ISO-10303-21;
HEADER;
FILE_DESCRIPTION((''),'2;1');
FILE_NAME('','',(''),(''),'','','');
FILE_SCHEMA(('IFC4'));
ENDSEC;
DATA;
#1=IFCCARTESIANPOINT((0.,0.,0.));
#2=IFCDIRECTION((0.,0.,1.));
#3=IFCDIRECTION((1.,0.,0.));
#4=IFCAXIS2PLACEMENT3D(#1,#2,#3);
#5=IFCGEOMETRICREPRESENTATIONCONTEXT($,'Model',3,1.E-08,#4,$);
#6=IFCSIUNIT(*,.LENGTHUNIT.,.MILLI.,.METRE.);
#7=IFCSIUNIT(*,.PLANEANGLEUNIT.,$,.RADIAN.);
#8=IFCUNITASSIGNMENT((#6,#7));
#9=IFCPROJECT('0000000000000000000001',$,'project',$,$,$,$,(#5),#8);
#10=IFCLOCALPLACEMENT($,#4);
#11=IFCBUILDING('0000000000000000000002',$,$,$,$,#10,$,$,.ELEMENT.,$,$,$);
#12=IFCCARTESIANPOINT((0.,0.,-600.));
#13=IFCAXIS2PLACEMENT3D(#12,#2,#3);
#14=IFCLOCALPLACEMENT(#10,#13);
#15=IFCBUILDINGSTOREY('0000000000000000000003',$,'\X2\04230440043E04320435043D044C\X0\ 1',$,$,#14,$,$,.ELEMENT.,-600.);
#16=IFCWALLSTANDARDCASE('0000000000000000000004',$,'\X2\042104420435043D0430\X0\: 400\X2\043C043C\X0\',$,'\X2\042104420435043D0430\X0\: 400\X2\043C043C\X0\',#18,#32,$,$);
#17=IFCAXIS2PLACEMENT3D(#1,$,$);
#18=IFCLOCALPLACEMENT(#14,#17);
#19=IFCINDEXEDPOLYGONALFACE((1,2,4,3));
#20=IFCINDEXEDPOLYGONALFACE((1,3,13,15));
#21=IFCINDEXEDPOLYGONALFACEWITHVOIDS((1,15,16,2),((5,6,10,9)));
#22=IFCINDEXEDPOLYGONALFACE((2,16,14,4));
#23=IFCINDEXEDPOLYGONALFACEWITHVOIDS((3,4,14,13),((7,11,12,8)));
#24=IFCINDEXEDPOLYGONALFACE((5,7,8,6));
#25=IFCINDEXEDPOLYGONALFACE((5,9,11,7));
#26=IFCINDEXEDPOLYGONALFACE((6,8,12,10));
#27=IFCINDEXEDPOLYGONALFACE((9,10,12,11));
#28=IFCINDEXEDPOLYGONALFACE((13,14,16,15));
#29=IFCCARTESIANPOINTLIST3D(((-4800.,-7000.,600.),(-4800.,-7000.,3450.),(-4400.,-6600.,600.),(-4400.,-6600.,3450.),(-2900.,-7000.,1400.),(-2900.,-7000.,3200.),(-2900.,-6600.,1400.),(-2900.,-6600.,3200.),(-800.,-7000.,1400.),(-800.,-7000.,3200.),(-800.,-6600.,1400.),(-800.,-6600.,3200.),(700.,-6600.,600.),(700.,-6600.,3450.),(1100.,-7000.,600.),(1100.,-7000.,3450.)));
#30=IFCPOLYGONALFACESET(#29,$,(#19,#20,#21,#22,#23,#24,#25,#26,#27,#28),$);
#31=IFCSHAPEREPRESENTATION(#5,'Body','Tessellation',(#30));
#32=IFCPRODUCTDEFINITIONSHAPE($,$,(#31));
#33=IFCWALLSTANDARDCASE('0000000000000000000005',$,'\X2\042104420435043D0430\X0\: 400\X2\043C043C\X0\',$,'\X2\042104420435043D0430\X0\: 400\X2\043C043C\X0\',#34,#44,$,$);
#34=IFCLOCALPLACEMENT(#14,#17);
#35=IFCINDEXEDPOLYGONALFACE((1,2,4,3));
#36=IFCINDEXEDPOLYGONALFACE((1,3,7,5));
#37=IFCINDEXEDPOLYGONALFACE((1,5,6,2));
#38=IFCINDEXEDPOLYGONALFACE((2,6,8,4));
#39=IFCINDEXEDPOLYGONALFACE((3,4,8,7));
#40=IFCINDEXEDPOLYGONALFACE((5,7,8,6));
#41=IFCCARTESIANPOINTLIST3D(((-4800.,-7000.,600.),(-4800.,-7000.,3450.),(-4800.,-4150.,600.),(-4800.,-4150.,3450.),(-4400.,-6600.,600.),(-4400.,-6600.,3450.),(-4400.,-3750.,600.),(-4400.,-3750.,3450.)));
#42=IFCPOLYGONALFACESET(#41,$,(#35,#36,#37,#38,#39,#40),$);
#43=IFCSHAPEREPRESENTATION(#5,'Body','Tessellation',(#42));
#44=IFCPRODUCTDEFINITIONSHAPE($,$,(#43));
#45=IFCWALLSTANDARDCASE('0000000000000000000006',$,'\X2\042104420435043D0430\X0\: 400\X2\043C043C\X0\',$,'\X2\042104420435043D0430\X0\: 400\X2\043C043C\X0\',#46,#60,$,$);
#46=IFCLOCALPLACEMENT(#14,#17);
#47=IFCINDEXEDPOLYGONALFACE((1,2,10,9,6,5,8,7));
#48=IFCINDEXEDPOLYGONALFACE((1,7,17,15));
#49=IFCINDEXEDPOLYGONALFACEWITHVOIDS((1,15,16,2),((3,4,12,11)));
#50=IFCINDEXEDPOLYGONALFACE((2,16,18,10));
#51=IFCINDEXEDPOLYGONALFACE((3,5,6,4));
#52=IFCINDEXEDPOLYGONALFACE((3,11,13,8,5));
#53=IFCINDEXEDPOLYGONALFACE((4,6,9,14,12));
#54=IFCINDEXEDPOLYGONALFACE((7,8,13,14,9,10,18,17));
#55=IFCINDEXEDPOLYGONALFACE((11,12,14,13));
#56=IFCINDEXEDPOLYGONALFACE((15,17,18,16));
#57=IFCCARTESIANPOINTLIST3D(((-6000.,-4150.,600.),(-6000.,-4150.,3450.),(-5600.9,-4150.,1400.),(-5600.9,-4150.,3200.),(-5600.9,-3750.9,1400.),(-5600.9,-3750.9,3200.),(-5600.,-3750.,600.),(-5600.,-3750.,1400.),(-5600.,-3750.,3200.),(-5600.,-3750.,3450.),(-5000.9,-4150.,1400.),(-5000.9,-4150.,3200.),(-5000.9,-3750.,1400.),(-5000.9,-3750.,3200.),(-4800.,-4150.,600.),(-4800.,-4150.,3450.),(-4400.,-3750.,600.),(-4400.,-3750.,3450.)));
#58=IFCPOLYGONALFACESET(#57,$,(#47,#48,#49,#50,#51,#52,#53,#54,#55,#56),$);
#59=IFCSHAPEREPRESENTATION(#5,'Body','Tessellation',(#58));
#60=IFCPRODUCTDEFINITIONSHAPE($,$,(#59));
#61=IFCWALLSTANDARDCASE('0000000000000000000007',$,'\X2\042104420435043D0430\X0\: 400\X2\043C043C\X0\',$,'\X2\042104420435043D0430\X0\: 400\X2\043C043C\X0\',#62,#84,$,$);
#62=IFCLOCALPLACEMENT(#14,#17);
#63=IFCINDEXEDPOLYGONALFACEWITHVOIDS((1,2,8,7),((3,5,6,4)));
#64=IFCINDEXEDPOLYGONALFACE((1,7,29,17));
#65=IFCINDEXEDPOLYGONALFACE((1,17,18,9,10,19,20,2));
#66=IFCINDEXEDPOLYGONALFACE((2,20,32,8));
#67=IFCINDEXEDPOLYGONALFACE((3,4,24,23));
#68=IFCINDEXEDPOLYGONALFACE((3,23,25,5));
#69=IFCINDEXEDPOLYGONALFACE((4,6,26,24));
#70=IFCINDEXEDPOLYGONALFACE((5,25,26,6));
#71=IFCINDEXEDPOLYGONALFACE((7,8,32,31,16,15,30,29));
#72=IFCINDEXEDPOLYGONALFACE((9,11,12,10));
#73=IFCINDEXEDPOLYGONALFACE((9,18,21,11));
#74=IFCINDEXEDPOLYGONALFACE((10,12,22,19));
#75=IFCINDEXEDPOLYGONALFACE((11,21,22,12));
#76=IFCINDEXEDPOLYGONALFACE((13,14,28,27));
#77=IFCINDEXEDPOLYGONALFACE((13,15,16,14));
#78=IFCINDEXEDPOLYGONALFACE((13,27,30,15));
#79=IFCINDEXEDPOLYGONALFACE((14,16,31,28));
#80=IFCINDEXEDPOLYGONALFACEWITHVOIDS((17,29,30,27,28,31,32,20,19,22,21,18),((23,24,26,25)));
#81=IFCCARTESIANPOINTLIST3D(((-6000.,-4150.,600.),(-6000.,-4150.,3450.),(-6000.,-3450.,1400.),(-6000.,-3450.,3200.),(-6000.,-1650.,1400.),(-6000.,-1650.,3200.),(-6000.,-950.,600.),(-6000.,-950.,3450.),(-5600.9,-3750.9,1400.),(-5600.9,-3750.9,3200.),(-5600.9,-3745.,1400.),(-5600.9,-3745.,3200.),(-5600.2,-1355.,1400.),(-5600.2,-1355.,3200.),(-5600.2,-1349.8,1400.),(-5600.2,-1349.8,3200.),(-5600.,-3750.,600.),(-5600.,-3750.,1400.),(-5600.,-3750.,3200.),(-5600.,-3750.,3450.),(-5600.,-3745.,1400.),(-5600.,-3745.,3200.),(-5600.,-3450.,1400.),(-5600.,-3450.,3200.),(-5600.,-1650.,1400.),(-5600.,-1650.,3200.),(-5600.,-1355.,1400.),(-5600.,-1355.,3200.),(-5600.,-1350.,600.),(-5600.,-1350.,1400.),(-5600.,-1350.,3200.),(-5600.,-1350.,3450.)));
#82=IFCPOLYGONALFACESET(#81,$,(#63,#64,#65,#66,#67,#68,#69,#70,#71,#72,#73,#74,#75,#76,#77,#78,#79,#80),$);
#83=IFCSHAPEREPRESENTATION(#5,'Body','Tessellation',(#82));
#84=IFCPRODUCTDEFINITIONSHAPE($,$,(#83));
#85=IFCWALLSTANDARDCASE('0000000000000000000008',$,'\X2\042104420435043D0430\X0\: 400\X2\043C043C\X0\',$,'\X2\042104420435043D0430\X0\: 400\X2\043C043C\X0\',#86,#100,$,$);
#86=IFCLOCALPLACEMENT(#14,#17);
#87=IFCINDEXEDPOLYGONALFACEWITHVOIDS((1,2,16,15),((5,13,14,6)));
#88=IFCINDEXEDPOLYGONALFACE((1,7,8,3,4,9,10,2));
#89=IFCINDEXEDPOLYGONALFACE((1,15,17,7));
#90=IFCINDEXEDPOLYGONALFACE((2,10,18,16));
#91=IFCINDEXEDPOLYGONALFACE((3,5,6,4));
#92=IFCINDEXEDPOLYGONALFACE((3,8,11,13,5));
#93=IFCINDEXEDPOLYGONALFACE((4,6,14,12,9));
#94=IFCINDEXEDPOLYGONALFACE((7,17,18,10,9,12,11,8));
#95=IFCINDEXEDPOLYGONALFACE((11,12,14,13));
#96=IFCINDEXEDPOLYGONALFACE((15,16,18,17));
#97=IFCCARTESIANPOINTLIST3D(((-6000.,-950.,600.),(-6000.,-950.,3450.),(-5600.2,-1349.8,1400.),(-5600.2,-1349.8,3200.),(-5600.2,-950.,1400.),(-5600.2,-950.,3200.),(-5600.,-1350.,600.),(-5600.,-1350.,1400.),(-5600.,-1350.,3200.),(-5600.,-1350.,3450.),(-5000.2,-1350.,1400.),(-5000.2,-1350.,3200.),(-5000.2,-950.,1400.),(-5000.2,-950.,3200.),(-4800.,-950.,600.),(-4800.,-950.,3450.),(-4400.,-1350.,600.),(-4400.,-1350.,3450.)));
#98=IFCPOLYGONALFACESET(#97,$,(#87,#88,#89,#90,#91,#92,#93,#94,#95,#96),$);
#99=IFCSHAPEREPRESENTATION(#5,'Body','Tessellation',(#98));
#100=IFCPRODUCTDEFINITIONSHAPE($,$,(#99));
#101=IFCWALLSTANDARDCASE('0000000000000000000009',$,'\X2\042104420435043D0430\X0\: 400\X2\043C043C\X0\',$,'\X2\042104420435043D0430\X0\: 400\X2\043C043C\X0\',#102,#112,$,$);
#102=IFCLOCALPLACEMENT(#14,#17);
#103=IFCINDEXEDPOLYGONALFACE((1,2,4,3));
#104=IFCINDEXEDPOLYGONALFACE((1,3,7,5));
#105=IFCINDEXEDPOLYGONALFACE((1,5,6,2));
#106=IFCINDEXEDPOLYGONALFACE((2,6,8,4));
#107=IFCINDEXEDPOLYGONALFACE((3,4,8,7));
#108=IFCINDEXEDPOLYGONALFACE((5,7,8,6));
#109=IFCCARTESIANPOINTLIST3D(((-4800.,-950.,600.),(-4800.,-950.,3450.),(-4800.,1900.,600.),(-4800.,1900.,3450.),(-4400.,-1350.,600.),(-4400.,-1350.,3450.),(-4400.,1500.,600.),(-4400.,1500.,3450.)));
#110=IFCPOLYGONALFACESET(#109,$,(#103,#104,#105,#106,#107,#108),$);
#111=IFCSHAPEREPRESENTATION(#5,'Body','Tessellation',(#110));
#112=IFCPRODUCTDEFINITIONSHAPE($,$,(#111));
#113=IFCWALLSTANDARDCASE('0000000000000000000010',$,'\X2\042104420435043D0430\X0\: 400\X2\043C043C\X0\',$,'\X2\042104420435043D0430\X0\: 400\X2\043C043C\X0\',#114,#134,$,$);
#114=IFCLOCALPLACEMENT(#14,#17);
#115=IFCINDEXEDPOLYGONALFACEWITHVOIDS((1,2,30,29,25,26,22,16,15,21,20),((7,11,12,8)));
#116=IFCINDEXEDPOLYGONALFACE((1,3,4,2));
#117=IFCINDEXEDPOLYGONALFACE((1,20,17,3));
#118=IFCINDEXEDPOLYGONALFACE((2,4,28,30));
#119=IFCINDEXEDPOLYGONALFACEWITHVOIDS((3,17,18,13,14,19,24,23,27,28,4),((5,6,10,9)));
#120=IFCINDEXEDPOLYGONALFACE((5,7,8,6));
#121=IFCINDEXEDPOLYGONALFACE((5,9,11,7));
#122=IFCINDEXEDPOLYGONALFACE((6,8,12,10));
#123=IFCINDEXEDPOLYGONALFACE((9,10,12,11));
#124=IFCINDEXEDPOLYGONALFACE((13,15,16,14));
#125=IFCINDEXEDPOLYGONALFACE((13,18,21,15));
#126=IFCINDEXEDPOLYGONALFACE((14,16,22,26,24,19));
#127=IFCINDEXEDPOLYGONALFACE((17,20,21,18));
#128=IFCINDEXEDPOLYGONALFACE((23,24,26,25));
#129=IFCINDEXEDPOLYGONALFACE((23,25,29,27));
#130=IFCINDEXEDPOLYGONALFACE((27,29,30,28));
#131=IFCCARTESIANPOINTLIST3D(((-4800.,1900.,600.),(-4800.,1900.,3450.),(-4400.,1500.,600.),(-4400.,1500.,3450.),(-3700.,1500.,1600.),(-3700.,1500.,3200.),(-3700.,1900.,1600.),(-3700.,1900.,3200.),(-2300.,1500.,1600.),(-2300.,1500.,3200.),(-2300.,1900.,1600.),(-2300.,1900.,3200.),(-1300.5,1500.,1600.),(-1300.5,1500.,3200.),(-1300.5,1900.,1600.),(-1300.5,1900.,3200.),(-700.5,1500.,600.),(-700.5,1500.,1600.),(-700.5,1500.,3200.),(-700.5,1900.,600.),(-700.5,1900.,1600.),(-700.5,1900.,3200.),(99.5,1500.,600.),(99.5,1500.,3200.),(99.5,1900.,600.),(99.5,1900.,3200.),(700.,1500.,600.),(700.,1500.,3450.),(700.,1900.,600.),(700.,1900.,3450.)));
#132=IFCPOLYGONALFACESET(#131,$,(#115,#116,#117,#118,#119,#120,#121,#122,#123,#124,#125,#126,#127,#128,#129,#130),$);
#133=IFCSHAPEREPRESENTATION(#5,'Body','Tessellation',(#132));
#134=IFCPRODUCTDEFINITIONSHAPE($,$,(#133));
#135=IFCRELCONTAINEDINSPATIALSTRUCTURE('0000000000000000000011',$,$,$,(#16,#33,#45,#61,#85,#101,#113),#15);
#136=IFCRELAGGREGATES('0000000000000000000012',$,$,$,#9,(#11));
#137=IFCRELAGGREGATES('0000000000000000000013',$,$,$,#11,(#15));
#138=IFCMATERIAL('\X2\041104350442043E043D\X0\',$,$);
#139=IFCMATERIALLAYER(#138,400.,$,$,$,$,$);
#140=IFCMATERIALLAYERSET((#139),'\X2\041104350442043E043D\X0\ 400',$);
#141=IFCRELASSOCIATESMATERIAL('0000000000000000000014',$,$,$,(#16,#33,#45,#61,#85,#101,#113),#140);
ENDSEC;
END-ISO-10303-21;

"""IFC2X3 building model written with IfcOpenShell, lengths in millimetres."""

from ifc_helpers import new_model, si_unit, frame, frame_2d, origin_with_axes, place, context, project, spatial, polyline, segment, composite_curve, rectangle, outline, extrude, material, layer, layer_set, layer_usage, element, save


model = new_model("IFC2X3")

# Units and contexts
model_context = context("Model", 3, precision=1e-08, world=origin_with_axes())
ifc_project = project(units=[si_unit("LENGTHUNIT", "METRE", prefix="MILLI"), si_unit("PLANEANGLEUNIT", "RADIAN")], contexts=[model_context])

# Building, storey
building_placement = place(None, origin_with_axes())
building = spatial("IfcBuilding", under=ifc_project, at=building_placement, CompositionType="ELEMENT")
storey_placement = place(building_placement, frame((0.0, 0.0, -600.0), z_axis=(0.0, 0.0, 1.0), x_axis=(1.0, 0.0, 0.0)))
storey = spatial("IfcBuildingStorey", under=building, at=storey_placement, Name="Уровень 1", CompositionType="ELEMENT", Elevation=-600.0)

# Shared definitions
ifc_material_1 = material(Name="Бетон")

# Wall, opening
ifc_layer_1 = layer(ifc_material_1, 400.0)
ifc_layer_set_1 = layer_set([ifc_layer_1], Name="Бетон 400")
ifc_layer_usage_1 = layer_usage(ifc_layer_set_1, "AXIS2", "NEGATIVE", 0.0)
wall_1_placement = place(storey_placement, frame((700.0, -7000.0, 600.0), z_axis=(0.0, 0.0, 1.0), x_axis=(-1.0, 0.0, 0.0)))
wall_1 = element("IfcWallStandardCase", 1, at=wall_1_placement, inside=storey, material=ifc_layer_usage_1, Name="Стена: 400мм", ObjectType="Стена: 400мм", context=model_context, shape_type="SweptSolid", body=[
    extrude(outline(composite_curve([segment(polyline([(0.0, -400.0), (5100.0, -400.0)]), True, "CONTINUOUS"), segment(polyline([(5100.0, -400.0), (5500.0, 0.0)]), True, "CONTINUOUS"), segment(polyline([(5500.0, 0.0), (-400.0, 0.0)]), True, "CONTINUOUS"), segment(polyline([(-400.0, 0.0), (0.0, -400.0)]), True, "CONTINUOUS")], self_intersect=False)), origin_with_axes(), (0.0, 0.0, 1.0), 2850.0),
])
opening_1_placement = place(wall_1_placement, frame((3600.0, 0.0, 800.0), z_axis=(0.0, 0.0, 1.0), x_axis=(-1.0, 0.0, 0.0)))
element("IfcOpeningElement", 2, at=opening_1_placement, cuts=wall_1, ObjectType="Opening", context=model_context, shape_type="SweptSolid", body=[
    extrude(rectangle(XDim=2100.0, YDim=1800.0, at=frame_2d((1050.0, 900.0), x_axis=(1.0, 0.0))), frame((0.0, -5.0, 0.0), z_axis=(0.0, -1.0, 0.0), x_axis=(1.0, 0.0, 0.0)), (0.0, 0.0, -1.0), 410.0),
])

# Wall
ifc_layer_usage_2 = layer_usage(ifc_layer_set_1, "AXIS2", "NEGATIVE", 0.0)
wall_2_placement = place(storey_placement, frame((-4800.0, -7000.0, 600.0), z_axis=(0.0, 0.0, 1.0), x_axis=(0.0, 1.0, 0.0)))
element("IfcWallStandardCase", 3, at=wall_2_placement, inside=storey, material=ifc_layer_usage_2, Name="Стена: 400мм", ObjectType="Стена: 400мм", context=model_context, shape_type="SweptSolid", body=[
    extrude(outline(composite_curve([segment(polyline([(400.0, -400.0), (3250.0, -400.0)]), True, "CONTINUOUS"), segment(polyline([(3250.0, -400.0), (2850.0, 0.0)]), True, "CONTINUOUS"), segment(polyline([(2850.0, 0.0), (0.0, 0.0)]), True, "CONTINUOUS"), segment(polyline([(0.0, 0.0), (400.0, -400.0)]), True, "CONTINUOUS")], self_intersect=False)), origin_with_axes(), (0.0, 0.0, 1.0), 2850.0),
])

# Wall, opening
ifc_layer_usage_3 = layer_usage(ifc_layer_set_1, "AXIS2", "NEGATIVE", 0.0)
wall_3_placement = place(storey_placement, frame((-4800.0, -4150.0, 600.0), z_axis=(0.0, 0.0, 1.0), x_axis=(-1.0, 0.0, 0.0)))
wall_3 = element("IfcWallStandardCase", 4, at=wall_3_placement, inside=storey, material=ifc_layer_usage_3, Name="Стена: 400мм", ObjectType="Стена: 400мм", context=model_context, shape_type="SweptSolid", body=[
    extrude(outline(composite_curve([segment(polyline([(-400.0, -400.0), (800.0, -400.0)]), True, "CONTINUOUS"), segment(polyline([(800.0, -400.0), (1200.0, 0.0)]), True, "CONTINUOUS"), segment(polyline([(1200.0, 0.0), (0.0, 0.0)]), True, "CONTINUOUS"), segment(polyline([(0.0, 0.0), (-400.0, -400.0)]), True, "CONTINUOUS")], self_intersect=False)), origin_with_axes(), (0.0, 0.0, 1.0), 2850.0),
])
opening_2_placement = place(wall_3_placement, frame((800.9, 0.0, 800.0), z_axis=(0.0, 0.0, 1.0), x_axis=(-1.0, 0.0, 0.0)))
element("IfcOpeningElement", 5, at=opening_2_placement, cuts=wall_3, ObjectType="Opening", context=model_context, shape_type="SweptSolid", body=[
    extrude(rectangle(XDim=600.0, YDim=1800.0, at=frame_2d((300.0, 900.0), x_axis=(1.0, 0.0))), frame((0.0, -5.0, 0.0), z_axis=(0.0, -1.0, 0.0), x_axis=(1.0, 0.0, 0.0)), (0.0, 0.0, -1.0), 410.0),
])

# Wall, openings
ifc_layer_usage_4 = layer_usage(ifc_layer_set_1, "AXIS2", "NEGATIVE", 0.0)
wall_4_placement = place(storey_placement, frame((-6000.0, -4150.0, 600.0), z_axis=(0.0, 0.0, 1.0), x_axis=(0.0, 1.0, 0.0)))
wall_4 = element("IfcWallStandardCase", 6, at=wall_4_placement, inside=storey, material=ifc_layer_usage_4, Name="Стена: 400мм", ObjectType="Стена: 400мм", context=model_context, shape_type="SweptSolid", body=[
    extrude(outline(composite_curve([segment(polyline([(400.0, -400.0), (2800.0, -400.0)]), True, "CONTINUOUS"), segment(polyline([(2800.0, -400.0), (3200.0, 0.0)]), True, "CONTINUOUS"), segment(polyline([(3200.0, 0.0), (0.0, 0.0)]), True, "CONTINUOUS"), segment(polyline([(0.0, 0.0), (400.0, -400.0)]), True, "CONTINUOUS")], self_intersect=False)), origin_with_axes(), (0.0, 0.0, 1.0), 2850.0),
])
opening_3_placement = place(wall_4_placement, frame((2500.0, 0.0, 800.0), z_axis=(0.0, 0.0, 1.0), x_axis=(-1.0, 0.0, 0.0)))
element("IfcOpeningElement", 7, at=opening_3_placement, cuts=wall_4, ObjectType="Opening", context=model_context, shape_type="SweptSolid", body=[
    extrude(rectangle(XDim=1800.0, YDim=1800.0, at=frame_2d((900.0, 900.0), x_axis=(1.0, 0.0))), frame((0.0, -5.0, 0.0), z_axis=(0.0, -1.0, 0.0), x_axis=(1.0, 0.0, 0.0)), (0.0, 0.0, -1.0), 410.0),
])
opening_4_placement = place(wall_4_placement, frame((0.0, -399.1, 800.0), z_axis=(0.0, 0.0, 1.0), x_axis=(0.0, -1.0, 0.0)))
element("IfcOpeningElement", 8, at=opening_4_placement, cuts=wall_4, ObjectType="Opening", context=model_context, shape_type="SweptSolid", body=[
    extrude(rectangle(XDim=600.0, YDim=1800.0, at=frame_2d((300.0, 900.0), x_axis=(1.0, 0.0))), frame((0.0, -5.0, 0.0), z_axis=(0.0, -1.0, 0.0), x_axis=(1.0, 0.0, 0.0)), (0.0, 0.0, -1.0), 410.0),
])
opening_5_placement = place(wall_4_placement, frame((3200.0, -999.8, 800.0), z_axis=(0.0, 0.0, 1.0), x_axis=(0.0, 1.0, 0.0)))
element("IfcOpeningElement", 9, at=opening_5_placement, cuts=wall_4, ObjectType="Opening", context=model_context, shape_type="SweptSolid", body=[
    extrude(rectangle(XDim=600.0, YDim=1800.0, at=frame_2d((300.0, 900.0), x_axis=(1.0, 0.0))), frame((0.0, -5.0, 0.0), z_axis=(0.0, -1.0, 0.0), x_axis=(1.0, 0.0, 0.0)), (0.0, 0.0, -1.0), 410.0),
])

# Wall, opening
ifc_layer_usage_5 = layer_usage(ifc_layer_set_1, "AXIS2", "NEGATIVE", 0.0)
wall_5_placement = place(storey_placement, frame((-6000.0, -950.0, 600.0), z_axis=(0.0, 0.0, 1.0), x_axis=(1.0, 0.0, 0.0)))
wall_5 = element("IfcWallStandardCase", 10, at=wall_5_placement, inside=storey, material=ifc_layer_usage_5, Name="Стена: 400мм", ObjectType="Стена: 400мм", context=model_context, shape_type="SweptSolid", body=[
    extrude(outline(composite_curve([segment(polyline([(400.0, -400.0), (1600.0, -400.0)]), True, "CONTINUOUS"), segment(polyline([(1600.0, -400.0), (1200.0, 0.0)]), True, "CONTINUOUS"), segment(polyline([(1200.0, 0.0), (0.0, 0.0)]), True, "CONTINUOUS"), segment(polyline([(0.0, 0.0), (400.0, -400.0)]), True, "CONTINUOUS")], self_intersect=False)), origin_with_axes(), (0.0, 0.0, 1.0), 2850.0),
])
opening_6_placement = place(wall_5_placement, frame((999.8, 0.0, 800.0), z_axis=(0.0, 0.0, 1.0), x_axis=(-1.0, 0.0, 0.0)))
element("IfcOpeningElement", 11, at=opening_6_placement, cuts=wall_5, ObjectType="Opening", context=model_context, shape_type="SweptSolid", body=[
    extrude(rectangle(XDim=600.0, YDim=1800.0, at=frame_2d((300.0, 900.0), x_axis=(1.0, 0.0))), frame((0.0, -5.0, 0.0), z_axis=(0.0, -1.0, 0.0), x_axis=(1.0, 0.0, 0.0)), (0.0, 0.0, -1.0), 410.0),
])

# Wall
ifc_layer_usage_6 = layer_usage(ifc_layer_set_1, "AXIS2", "NEGATIVE", 0.0)
wall_6_placement = place(storey_placement, frame((-4800.0, -950.0, 600.0), z_axis=(0.0, 0.0, 1.0), x_axis=(0.0, 1.0, 0.0)))
element("IfcWallStandardCase", 12, at=wall_6_placement, inside=storey, material=ifc_layer_usage_6, Name="Стена: 400мм", ObjectType="Стена: 400мм", context=model_context, shape_type="SweptSolid", body=[
    extrude(outline(composite_curve([segment(polyline([(-400.0, -400.0), (2450.0, -400.0)]), True, "CONTINUOUS"), segment(polyline([(2450.0, -400.0), (2850.0, 0.0)]), True, "CONTINUOUS"), segment(polyline([(2850.0, 0.0), (0.0, 0.0)]), True, "CONTINUOUS"), segment(polyline([(0.0, 0.0), (-400.0, -400.0)]), True, "CONTINUOUS")], self_intersect=False)), origin_with_axes(), (0.0, 0.0, 1.0), 2850.0),
])

# Wall, openings
ifc_layer_usage_7 = layer_usage(ifc_layer_set_1, "AXIS2", "NEGATIVE", 0.0)
wall_7_placement = place(storey_placement, frame((-4800.0, 1900.0, 600.0), z_axis=(0.0, 0.0, 1.0), x_axis=(1.0, 0.0, 0.0)))
wall_7 = element("IfcWallStandardCase", 13, at=wall_7_placement, inside=storey, material=ifc_layer_usage_7, Name="Стена: 400мм", ObjectType="Стена: 400мм", context=model_context, shape_type="SweptSolid", body=[
    extrude(outline(composite_curve([segment(polyline([(400.0, -400.0), (5500.0, -400.0)]), True, "CONTINUOUS"), segment(polyline([(5500.0, -400.0), (5500.0, 0.0)]), True, "CONTINUOUS"), segment(polyline([(5500.0, 0.0), (0.0, 0.0)]), True, "CONTINUOUS"), segment(polyline([(0.0, 0.0), (400.0, -400.0)]), True, "CONTINUOUS")], self_intersect=False)), origin_with_axes(), (0.0, 0.0, 1.0), 2850.0),
])
opening_7_placement = place(wall_7_placement, frame((4899.5, 0.0, 0.0), z_axis=(0.0, 0.0, 1.0), x_axis=(-1.0, 0.0, 0.0)))
element("IfcOpeningElement", 14, at=opening_7_placement, cuts=wall_7, ObjectType="Opening", context=model_context, shape_type="SweptSolid", body=[
    extrude(rectangle(XDim=800.0, YDim=2600.0, at=frame_2d((400.0, 1300.0), x_axis=(1.0, 0.0))), frame((0.0, -5.0, 0.0), z_axis=(0.0, -1.0, 0.0), x_axis=(1.0, 0.0, 0.0)), (0.0, 0.0, -1.0), 410.0),
])
opening_8_placement = place(wall_7_placement, frame((2500.0, 0.0, 1000.0), z_axis=(0.0, 0.0, 1.0), x_axis=(-1.0, 0.0, 0.0)))
element("IfcOpeningElement", 15, at=opening_8_placement, cuts=wall_7, ObjectType="Opening", context=model_context, shape_type="SweptSolid", body=[
    extrude(rectangle(XDim=1400.0, YDim=1600.0, at=frame_2d((700.0, 800.0), x_axis=(1.0, 0.0))), frame((0.0, -5.0, 0.0), z_axis=(0.0, -1.0, 0.0), x_axis=(1.0, 0.0, 0.0)), (0.0, 0.0, -1.0), 410.0),
])
opening_9_placement = place(wall_7_placement, frame((4099.5, 0.0, 1000.0), z_axis=(0.0, 0.0, 1.0), x_axis=(-1.0, 0.0, 0.0)))
element("IfcOpeningElement", 16, at=opening_9_placement, cuts=wall_7, ObjectType="Opening", context=model_context, shape_type="SweptSolid", body=[
    extrude(rectangle(XDim=600.0, YDim=1600.0, at=frame_2d((300.0, 800.0), x_axis=(1.0, 0.0))), frame((0.0, -5.0, 0.0), z_axis=(0.0, -1.0, 0.0), x_axis=(1.0, 0.0, 0.0)), (0.0, 0.0, -1.0), 410.0),
])

save(model, "model.ifc")
